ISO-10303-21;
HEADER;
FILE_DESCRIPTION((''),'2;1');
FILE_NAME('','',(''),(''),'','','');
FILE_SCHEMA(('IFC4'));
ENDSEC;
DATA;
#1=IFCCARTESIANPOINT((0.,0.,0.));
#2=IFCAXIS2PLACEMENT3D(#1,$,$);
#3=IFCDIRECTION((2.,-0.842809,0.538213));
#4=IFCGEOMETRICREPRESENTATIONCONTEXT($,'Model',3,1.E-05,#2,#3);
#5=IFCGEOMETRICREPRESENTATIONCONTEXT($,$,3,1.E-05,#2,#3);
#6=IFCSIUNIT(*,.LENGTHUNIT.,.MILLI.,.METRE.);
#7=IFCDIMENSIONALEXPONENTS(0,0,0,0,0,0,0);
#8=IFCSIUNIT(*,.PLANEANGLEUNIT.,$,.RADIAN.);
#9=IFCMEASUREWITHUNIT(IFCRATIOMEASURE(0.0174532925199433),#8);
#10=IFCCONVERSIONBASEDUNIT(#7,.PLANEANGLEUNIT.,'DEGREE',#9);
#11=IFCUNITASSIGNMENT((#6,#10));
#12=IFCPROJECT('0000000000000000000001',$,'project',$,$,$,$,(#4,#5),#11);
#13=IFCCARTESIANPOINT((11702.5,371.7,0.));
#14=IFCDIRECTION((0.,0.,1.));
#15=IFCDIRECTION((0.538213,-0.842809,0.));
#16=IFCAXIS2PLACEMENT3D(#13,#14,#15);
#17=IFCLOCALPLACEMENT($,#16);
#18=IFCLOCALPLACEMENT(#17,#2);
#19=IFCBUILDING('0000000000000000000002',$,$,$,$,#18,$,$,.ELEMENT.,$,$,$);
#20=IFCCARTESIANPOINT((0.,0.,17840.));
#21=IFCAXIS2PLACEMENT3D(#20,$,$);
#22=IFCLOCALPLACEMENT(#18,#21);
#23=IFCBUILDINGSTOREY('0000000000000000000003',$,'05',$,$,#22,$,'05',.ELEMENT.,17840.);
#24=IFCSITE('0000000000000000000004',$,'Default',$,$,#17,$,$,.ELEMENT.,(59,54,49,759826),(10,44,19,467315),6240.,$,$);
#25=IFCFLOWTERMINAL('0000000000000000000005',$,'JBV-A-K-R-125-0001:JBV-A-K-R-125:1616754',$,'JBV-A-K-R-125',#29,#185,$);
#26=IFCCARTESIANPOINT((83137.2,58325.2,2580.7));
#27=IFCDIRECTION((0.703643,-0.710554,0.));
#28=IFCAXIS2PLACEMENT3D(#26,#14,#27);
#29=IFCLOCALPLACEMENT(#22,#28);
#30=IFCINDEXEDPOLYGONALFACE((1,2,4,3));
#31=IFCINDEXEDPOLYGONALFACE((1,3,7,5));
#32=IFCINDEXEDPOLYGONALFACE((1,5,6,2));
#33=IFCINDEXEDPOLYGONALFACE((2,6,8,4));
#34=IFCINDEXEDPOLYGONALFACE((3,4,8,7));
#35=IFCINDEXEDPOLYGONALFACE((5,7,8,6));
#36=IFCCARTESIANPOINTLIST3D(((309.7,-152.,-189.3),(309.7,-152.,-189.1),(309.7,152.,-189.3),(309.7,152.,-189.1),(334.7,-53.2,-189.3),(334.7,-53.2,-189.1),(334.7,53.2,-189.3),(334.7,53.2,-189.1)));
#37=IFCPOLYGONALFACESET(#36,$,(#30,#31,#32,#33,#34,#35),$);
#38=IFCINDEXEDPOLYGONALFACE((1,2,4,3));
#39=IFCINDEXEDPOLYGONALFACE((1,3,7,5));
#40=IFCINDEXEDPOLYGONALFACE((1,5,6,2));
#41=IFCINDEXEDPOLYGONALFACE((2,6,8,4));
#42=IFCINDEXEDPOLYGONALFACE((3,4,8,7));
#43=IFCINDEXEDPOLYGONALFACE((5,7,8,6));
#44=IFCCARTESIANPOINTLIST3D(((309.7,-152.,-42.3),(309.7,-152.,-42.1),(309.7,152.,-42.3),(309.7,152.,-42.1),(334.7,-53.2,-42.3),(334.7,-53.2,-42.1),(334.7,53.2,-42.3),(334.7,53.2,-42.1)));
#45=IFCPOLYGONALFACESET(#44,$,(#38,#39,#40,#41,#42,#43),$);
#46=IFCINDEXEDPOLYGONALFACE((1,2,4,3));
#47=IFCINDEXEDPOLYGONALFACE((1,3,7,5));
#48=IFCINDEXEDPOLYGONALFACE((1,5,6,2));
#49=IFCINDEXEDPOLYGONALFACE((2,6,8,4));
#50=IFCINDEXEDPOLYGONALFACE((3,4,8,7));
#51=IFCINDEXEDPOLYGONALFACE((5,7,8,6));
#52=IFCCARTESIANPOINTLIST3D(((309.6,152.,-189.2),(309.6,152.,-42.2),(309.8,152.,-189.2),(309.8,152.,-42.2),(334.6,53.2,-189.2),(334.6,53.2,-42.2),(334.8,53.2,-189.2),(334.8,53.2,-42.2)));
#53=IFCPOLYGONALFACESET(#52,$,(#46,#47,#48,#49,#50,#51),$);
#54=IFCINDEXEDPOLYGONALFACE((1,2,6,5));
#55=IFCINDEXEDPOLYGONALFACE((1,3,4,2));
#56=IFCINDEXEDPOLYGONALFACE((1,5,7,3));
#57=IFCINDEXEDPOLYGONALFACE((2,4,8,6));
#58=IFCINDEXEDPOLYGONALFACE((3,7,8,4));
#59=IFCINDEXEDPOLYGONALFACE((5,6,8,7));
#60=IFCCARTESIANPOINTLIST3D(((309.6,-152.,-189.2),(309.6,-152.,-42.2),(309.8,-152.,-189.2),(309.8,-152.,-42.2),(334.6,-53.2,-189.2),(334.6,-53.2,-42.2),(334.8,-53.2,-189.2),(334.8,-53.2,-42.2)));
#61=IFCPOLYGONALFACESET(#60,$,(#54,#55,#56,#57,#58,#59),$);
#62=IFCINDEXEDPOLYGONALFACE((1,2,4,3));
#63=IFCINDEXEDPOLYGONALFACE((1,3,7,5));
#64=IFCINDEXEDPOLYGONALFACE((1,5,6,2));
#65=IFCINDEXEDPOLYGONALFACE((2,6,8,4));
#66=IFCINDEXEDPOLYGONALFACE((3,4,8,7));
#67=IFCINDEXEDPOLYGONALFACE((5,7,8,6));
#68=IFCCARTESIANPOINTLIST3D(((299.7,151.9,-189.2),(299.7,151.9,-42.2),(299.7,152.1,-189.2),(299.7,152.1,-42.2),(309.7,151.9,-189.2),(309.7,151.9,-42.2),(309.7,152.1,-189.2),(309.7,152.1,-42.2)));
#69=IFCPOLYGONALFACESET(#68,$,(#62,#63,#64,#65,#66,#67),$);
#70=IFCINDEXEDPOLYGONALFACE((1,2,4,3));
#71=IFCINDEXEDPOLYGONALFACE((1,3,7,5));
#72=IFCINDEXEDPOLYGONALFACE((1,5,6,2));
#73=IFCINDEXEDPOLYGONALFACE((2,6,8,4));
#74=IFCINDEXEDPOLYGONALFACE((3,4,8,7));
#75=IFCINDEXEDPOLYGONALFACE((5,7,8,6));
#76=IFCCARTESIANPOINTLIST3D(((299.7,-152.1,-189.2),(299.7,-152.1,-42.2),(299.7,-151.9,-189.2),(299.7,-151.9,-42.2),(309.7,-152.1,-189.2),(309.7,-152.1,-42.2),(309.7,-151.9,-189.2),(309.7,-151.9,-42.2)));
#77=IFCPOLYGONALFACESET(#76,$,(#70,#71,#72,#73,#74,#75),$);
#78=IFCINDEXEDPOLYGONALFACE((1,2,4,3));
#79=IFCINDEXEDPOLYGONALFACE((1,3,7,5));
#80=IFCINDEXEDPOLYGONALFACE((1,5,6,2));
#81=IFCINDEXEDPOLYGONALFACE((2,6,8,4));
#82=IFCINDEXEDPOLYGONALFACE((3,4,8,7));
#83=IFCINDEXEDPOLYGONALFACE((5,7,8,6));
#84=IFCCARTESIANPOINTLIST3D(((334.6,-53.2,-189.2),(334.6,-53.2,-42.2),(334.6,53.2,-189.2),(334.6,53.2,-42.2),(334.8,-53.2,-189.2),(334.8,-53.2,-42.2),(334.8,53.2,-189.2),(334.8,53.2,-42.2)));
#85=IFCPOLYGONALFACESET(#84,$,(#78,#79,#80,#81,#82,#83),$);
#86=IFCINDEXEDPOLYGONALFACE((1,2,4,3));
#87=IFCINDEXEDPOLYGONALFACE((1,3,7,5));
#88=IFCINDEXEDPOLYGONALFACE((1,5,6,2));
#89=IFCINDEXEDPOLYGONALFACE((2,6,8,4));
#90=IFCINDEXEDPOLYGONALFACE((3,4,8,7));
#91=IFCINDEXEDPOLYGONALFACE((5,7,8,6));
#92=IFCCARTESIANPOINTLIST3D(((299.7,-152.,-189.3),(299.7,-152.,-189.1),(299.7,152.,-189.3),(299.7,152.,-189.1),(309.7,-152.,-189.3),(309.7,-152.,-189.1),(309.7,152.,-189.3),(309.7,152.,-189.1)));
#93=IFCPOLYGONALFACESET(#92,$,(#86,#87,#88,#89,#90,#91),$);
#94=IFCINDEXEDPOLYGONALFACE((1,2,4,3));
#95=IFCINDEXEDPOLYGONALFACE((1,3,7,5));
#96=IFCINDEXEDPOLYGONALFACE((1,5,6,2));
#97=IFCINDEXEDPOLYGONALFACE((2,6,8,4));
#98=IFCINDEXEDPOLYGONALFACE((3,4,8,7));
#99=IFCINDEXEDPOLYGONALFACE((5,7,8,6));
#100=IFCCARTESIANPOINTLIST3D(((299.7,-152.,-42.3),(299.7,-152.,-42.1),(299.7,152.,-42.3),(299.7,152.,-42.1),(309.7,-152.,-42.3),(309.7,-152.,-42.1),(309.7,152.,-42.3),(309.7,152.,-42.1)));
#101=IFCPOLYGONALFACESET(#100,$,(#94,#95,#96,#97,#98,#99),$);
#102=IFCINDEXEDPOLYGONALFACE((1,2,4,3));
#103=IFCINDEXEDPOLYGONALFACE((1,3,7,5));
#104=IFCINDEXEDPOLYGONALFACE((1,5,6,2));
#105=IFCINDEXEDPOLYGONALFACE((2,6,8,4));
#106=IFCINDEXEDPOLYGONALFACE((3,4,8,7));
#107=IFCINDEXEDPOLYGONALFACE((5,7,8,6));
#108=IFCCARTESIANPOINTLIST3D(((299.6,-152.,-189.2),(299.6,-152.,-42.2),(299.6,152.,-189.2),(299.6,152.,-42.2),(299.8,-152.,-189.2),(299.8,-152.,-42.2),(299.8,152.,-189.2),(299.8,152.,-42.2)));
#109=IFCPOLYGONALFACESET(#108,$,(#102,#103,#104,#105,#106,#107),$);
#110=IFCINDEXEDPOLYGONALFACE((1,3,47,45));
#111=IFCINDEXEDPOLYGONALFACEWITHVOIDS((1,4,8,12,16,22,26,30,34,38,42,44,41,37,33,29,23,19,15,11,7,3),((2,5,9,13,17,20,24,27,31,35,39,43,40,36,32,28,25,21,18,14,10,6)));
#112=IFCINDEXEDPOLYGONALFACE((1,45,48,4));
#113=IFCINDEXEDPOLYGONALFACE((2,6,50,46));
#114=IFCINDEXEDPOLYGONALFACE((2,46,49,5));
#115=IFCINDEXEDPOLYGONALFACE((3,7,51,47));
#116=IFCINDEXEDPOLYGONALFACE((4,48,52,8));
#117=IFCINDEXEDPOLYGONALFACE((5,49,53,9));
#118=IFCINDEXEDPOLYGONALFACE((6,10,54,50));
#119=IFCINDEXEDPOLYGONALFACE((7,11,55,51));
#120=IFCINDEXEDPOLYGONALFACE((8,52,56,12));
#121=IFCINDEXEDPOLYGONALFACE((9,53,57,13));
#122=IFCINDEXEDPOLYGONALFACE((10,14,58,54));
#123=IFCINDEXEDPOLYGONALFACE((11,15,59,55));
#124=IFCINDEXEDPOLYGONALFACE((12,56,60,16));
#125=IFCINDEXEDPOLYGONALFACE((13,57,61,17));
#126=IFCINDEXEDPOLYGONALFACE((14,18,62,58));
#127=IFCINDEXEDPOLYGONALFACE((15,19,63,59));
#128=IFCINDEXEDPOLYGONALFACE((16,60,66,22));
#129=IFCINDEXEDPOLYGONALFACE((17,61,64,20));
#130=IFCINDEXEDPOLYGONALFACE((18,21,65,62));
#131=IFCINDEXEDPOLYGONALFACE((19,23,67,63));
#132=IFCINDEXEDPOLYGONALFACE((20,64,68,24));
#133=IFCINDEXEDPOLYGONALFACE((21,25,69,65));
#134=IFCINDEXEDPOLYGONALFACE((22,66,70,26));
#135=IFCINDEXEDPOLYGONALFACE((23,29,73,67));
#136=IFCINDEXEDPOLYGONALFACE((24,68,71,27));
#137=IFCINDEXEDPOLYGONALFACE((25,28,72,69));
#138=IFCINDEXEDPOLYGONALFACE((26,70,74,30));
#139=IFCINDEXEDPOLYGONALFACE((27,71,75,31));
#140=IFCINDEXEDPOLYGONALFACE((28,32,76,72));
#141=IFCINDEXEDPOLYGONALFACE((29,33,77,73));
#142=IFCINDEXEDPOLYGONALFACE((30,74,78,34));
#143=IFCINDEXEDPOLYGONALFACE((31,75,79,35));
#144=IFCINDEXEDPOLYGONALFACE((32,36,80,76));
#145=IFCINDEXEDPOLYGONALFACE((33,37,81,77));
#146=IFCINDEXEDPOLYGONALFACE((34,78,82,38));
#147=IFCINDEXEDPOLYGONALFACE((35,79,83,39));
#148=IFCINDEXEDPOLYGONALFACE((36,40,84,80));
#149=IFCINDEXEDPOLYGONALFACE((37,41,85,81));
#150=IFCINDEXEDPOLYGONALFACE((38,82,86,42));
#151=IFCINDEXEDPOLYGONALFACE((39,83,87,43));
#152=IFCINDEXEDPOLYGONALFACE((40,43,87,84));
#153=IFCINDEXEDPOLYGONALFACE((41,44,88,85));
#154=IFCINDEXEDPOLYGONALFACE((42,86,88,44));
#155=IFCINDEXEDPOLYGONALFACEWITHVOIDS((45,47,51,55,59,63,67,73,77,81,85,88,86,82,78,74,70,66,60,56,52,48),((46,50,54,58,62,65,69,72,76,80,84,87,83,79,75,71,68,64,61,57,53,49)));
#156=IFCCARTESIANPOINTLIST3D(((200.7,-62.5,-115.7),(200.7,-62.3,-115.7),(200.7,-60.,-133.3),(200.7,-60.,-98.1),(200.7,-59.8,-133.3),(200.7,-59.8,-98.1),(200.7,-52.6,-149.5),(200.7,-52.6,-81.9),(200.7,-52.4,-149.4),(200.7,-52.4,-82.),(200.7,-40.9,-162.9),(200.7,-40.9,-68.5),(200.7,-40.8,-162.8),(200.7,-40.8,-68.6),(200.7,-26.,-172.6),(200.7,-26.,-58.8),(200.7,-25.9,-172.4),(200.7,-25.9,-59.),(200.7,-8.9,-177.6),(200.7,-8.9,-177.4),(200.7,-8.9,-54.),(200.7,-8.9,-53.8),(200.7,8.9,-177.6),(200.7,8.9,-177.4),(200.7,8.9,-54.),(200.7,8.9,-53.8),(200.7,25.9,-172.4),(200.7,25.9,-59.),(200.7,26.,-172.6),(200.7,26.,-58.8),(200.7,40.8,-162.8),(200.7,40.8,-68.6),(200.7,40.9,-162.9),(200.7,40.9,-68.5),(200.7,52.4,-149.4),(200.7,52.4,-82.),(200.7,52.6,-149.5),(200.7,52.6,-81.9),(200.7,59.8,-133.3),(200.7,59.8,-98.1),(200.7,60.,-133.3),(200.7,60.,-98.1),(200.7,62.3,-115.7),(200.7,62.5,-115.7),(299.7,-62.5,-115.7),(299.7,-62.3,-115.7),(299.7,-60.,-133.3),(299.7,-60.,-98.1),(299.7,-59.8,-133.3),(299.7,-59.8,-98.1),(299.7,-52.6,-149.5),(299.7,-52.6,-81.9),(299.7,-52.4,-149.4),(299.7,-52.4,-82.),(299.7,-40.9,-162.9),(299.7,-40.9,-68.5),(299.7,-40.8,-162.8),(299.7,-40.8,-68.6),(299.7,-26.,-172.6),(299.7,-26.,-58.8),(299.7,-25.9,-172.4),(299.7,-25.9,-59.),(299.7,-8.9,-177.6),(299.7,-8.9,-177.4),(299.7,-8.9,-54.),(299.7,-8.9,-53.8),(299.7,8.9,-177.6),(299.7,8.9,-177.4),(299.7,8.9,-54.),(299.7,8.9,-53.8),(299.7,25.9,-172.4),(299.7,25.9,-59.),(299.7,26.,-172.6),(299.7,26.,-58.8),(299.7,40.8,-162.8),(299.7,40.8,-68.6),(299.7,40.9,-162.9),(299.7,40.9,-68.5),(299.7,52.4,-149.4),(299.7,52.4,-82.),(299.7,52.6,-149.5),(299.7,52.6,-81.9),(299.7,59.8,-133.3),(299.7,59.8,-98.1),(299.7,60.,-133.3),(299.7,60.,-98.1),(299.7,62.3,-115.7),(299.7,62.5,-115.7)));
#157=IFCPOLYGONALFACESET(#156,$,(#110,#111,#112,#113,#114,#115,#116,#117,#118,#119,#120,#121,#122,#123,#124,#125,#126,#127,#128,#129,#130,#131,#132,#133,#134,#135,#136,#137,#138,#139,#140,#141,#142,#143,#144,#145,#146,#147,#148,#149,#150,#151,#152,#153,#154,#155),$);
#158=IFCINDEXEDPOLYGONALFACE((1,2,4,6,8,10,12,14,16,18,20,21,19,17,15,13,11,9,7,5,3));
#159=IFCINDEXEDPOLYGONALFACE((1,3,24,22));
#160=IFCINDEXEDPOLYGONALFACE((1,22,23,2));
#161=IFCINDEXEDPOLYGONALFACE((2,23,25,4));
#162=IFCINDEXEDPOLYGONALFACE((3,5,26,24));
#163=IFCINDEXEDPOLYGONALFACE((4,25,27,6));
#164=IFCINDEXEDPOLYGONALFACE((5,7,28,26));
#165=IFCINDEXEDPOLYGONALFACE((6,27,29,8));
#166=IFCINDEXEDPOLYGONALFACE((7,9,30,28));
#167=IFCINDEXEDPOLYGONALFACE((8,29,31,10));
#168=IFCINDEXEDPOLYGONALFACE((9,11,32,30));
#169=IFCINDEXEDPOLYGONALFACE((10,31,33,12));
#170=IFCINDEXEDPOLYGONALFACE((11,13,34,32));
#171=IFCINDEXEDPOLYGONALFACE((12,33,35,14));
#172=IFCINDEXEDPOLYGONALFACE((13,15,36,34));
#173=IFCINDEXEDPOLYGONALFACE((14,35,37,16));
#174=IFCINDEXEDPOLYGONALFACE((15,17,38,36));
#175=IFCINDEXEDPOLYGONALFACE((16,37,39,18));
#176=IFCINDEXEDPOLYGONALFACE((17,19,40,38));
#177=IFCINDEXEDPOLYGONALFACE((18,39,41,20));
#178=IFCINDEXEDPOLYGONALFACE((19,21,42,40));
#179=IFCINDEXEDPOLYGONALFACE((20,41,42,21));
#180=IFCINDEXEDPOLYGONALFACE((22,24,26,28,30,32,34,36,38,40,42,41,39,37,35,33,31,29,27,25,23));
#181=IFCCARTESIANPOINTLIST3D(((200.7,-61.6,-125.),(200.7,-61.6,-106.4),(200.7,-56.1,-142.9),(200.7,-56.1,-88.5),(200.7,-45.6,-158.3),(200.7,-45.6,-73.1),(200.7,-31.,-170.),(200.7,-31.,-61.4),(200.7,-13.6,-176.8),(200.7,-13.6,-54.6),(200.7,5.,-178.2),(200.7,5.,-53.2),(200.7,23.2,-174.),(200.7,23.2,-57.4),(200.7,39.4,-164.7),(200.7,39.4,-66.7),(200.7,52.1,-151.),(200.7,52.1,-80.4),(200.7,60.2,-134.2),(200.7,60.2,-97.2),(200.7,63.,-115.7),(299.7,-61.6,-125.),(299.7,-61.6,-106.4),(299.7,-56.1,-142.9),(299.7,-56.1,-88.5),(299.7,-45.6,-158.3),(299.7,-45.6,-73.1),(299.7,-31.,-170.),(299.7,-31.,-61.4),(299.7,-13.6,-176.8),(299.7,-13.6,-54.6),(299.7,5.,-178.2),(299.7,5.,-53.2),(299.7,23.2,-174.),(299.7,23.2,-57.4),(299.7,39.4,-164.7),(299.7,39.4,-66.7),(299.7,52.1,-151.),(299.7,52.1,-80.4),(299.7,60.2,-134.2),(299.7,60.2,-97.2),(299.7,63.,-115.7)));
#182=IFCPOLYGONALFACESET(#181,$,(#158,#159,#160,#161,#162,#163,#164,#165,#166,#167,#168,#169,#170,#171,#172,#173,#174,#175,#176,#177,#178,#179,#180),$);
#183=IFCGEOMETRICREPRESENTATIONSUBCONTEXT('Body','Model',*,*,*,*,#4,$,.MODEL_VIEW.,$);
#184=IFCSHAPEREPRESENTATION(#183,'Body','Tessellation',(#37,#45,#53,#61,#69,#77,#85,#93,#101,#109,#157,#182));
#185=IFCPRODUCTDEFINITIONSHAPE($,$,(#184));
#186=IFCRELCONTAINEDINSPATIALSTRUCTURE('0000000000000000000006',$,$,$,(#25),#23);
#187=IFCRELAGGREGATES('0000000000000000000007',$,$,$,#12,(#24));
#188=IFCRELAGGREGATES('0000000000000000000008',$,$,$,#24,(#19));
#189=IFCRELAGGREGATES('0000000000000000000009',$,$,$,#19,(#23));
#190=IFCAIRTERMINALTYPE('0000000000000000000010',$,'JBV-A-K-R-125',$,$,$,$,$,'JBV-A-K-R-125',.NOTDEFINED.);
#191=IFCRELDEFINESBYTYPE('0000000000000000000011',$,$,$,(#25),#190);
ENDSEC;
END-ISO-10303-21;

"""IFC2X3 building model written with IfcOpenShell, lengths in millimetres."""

from ifc_helpers import new_model, entity, si_unit, converted_unit, direction, frame, frame_2d, origin, origin_2d_with_axis, place, context, subcontext, project, spatial, polyline, circle_curve, parameter, trimmed, segment, composite_curve, rectangle, circle, outline, extrude, source, transform, mapped, type_object, type_shapes, element, save


model = new_model("IFC2X3")

# Units and contexts
model_context = context("Model", 3, precision=1e-05, world=origin(), true_north=direction((2.0, -0.842809, 0.538213)))
context_of_model = context(None, 3, precision=1e-05, world=origin(), true_north=direction((2.0, -0.842809, 0.538213)))
body_context = subcontext(model_context, "Body", "Model", "MODEL_VIEW")
ifc_project = project(units=[si_unit("LENGTHUNIT", "METRE", prefix="MILLI"), converted_unit("PLANEANGLEUNIT", "DEGREE", entity("IfcRatioMeasure", 0.0174532925199433), si_unit("PLANEANGLEUNIT", "RADIAN"), dimensions=[0, 0, 0, 0, 0, 0, 0])], contexts=[model_context, context_of_model])

# Site, building, storey
site_placement = place(None, frame((11702.5, 371.7, 0.0), z_axis=(0.0, 0.0, 1.0), x_axis=(0.538213, -0.842809, 0.0)))
site = spatial("IfcSite", under=ifc_project, at=site_placement, Name="Default", CompositionType="ELEMENT", RefLatitude=(59, 54, 49, 759826), RefLongitude=(10, 44, 19, 467315), RefElevation=6240.0)
building_placement = place(site_placement, origin())
building = spatial("IfcBuilding", under=site, at=building_placement, CompositionType="ELEMENT")
storey_placement = place(building_placement, frame((0.0, 0.0, 17840.0)))
storey = spatial("IfcBuildingStorey", under=building, at=storey_placement, Name="05", LongName="05", CompositionType="ELEMENT", Elevation=17840.0)

# Flow terminal
air_terminal_type_1 = type_object("IfcAirTerminalType", Name="JBV-A-K-R-125", ElementType="JBV-A-K-R-125", PredefinedType="NOTDEFINED")
shared_shape_1 = source(origin(), body_context, "Body", "SweptSolid", [
    extrude(outline(polyline([(-152.0, -12.5), (152.0, -12.5), (53.2, 12.5), (-53.2, 12.5), (-152.0, -12.5)])), frame((322.2, 0.0, -189.3), z_axis=(0.0, 0.0, 1.0), x_axis=(0.0, -1.0, 0.0)), (0.0, 0.0, 1.0), 0.2),
    extrude(outline(polyline([(-152.0, -12.5), (152.0, -12.5), (53.2, 12.5), (-53.2, 12.5), (-152.0, -12.5)])), frame((322.2, 0.0, -42.3), z_axis=(0.0, 0.0, 1.0), x_axis=(0.0, -1.0, 0.0)), (0.0, 0.0, 1.0), 0.2),
    extrude(rectangle(XDim=0.2, YDim=101.9, at=frame_2d((0.0, 0.0), x_axis=(1.0, 0.0))), frame((322.2, 102.6, -189.2), z_axis=(0.0, 0.0, 1.0), x_axis=(0.969446, 0.245305, 0.0)), (0.0, 0.0, 1.0), 147.0),
    extrude(rectangle(XDim=0.2, YDim=101.9, at=frame_2d((0.0, 0.0), x_axis=(1.0, 0.0))), frame((322.2, -102.6, -189.2), z_axis=(0.0, 0.0, 1.0), x_axis=(-0.969446, 0.245305, 0.0)), (0.0, 0.0, 1.0), 147.0),
    extrude(rectangle(XDim=0.2, YDim=10.0, at=frame_2d((0.0, 0.0), x_axis=(1.0, 0.0))), frame((304.7, 152.0, -189.2), z_axis=(0.0, 0.0, 1.0), x_axis=(0.0, 1.0, 0.0)), (0.0, 0.0, 1.0), 147.0),
    extrude(rectangle(XDim=0.2, YDim=10.0, at=frame_2d((0.0, 0.0), x_axis=(1.0, 0.0))), frame((304.7, -152.0, -189.2), z_axis=(0.0, 0.0, 1.0), x_axis=(0.0, 1.0, 0.0)), (0.0, 0.0, 1.0), 147.0),
    extrude(rectangle(XDim=0.2, YDim=106.4, at=frame_2d((0.0, 0.0), x_axis=(1.0, 0.0))), frame((334.7, 0.0, -189.2)), (0.0, 0.0, 1.0), 147.0),
    extrude(rectangle(XDim=304.0, YDim=10.0, at=frame_2d((0.0, 0.0), x_axis=(1.0, 0.0))), frame((304.7, 0.0, -189.3), z_axis=(0.0, 0.0, 1.0), x_axis=(0.0, -1.0, 0.0)), (0.0, 0.0, 1.0), 0.2),
    extrude(rectangle(XDim=304.0, YDim=10.0, at=frame_2d((0.0, 0.0), x_axis=(1.0, 0.0))), frame((304.7, 0.0, -42.3), z_axis=(0.0, 0.0, 1.0), x_axis=(0.0, -1.0, 0.0)), (0.0, 0.0, 1.0), 0.2),
    extrude(rectangle(XDim=0.2, YDim=304.0, at=frame_2d((0.0, 0.0), x_axis=(1.0, 0.0))), frame((299.7, 0.0, -189.2)), (0.0, 0.0, 1.0), 147.0),
    extrude(outline(composite_curve([segment(trimmed(circle_curve(origin_2d_with_axis(), 62.5), [parameter(0.0)], [parameter(180.0)], True, "PARAMETER"), True, "CONTINUOUS"), segment(trimmed(circle_curve(origin_2d_with_axis(), 62.5), [parameter(180.0)], [parameter(360.0)], True, "PARAMETER"), True, "CONTINUOUS")], self_intersect=False), holes=[composite_curve([segment(trimmed(circle_curve(origin_2d_with_axis(), 62.3), [parameter(180.0)], [parameter(360.0)], True, "PARAMETER"), False, "CONTINUOUS"), segment(trimmed(circle_curve(origin_2d_with_axis(), 62.3), [parameter(0.0)], [parameter(180.0)], True, "PARAMETER"), False, "CONTINUOUS")], self_intersect=False)]), frame((200.7, 0.0, -115.7), z_axis=(1.0, 0.0, 0.0), x_axis=(0.0, 1.0, 0.0)), (0.0, 0.0, 1.0), 99.0),
    extrude(circle(Radius=62.6, at=frame_2d((0.0, 0.0), x_axis=(1.0, 0.0))), frame((200.7, 0.3, -115.7), z_axis=(1.0, 0.0, 0.0), x_axis=(0.0, 1.0, 0.0)), (0.0, 0.0, 1.0), 99.0),
])
type_shapes(air_terminal_type_1, [shared_shape_1])
for number, where, z_axis, x_axis, name in (
    (1, (83137.2, 58325.2, 2580.7), (0.0, 0.0, 1.0), (0.703643, -0.710554, 0.0), "JBV-A-K-R-125-0001:JBV-A-K-R-125:1616754"),
):
    element("IfcFlowTerminal", number, at=place(storey_placement, frame(where, z_axis=z_axis, x_axis=x_axis)), inside=storey, type_object=air_terminal_type_1, Name=name, ObjectType="JBV-A-K-R-125", context=body_context, shape_type="MappedRepresentation", body=[
        mapped(shared_shape_1, transform((0.0, 0.0, 0.0), scale=1.0)),
    ])

save(model, "model.ifc")
